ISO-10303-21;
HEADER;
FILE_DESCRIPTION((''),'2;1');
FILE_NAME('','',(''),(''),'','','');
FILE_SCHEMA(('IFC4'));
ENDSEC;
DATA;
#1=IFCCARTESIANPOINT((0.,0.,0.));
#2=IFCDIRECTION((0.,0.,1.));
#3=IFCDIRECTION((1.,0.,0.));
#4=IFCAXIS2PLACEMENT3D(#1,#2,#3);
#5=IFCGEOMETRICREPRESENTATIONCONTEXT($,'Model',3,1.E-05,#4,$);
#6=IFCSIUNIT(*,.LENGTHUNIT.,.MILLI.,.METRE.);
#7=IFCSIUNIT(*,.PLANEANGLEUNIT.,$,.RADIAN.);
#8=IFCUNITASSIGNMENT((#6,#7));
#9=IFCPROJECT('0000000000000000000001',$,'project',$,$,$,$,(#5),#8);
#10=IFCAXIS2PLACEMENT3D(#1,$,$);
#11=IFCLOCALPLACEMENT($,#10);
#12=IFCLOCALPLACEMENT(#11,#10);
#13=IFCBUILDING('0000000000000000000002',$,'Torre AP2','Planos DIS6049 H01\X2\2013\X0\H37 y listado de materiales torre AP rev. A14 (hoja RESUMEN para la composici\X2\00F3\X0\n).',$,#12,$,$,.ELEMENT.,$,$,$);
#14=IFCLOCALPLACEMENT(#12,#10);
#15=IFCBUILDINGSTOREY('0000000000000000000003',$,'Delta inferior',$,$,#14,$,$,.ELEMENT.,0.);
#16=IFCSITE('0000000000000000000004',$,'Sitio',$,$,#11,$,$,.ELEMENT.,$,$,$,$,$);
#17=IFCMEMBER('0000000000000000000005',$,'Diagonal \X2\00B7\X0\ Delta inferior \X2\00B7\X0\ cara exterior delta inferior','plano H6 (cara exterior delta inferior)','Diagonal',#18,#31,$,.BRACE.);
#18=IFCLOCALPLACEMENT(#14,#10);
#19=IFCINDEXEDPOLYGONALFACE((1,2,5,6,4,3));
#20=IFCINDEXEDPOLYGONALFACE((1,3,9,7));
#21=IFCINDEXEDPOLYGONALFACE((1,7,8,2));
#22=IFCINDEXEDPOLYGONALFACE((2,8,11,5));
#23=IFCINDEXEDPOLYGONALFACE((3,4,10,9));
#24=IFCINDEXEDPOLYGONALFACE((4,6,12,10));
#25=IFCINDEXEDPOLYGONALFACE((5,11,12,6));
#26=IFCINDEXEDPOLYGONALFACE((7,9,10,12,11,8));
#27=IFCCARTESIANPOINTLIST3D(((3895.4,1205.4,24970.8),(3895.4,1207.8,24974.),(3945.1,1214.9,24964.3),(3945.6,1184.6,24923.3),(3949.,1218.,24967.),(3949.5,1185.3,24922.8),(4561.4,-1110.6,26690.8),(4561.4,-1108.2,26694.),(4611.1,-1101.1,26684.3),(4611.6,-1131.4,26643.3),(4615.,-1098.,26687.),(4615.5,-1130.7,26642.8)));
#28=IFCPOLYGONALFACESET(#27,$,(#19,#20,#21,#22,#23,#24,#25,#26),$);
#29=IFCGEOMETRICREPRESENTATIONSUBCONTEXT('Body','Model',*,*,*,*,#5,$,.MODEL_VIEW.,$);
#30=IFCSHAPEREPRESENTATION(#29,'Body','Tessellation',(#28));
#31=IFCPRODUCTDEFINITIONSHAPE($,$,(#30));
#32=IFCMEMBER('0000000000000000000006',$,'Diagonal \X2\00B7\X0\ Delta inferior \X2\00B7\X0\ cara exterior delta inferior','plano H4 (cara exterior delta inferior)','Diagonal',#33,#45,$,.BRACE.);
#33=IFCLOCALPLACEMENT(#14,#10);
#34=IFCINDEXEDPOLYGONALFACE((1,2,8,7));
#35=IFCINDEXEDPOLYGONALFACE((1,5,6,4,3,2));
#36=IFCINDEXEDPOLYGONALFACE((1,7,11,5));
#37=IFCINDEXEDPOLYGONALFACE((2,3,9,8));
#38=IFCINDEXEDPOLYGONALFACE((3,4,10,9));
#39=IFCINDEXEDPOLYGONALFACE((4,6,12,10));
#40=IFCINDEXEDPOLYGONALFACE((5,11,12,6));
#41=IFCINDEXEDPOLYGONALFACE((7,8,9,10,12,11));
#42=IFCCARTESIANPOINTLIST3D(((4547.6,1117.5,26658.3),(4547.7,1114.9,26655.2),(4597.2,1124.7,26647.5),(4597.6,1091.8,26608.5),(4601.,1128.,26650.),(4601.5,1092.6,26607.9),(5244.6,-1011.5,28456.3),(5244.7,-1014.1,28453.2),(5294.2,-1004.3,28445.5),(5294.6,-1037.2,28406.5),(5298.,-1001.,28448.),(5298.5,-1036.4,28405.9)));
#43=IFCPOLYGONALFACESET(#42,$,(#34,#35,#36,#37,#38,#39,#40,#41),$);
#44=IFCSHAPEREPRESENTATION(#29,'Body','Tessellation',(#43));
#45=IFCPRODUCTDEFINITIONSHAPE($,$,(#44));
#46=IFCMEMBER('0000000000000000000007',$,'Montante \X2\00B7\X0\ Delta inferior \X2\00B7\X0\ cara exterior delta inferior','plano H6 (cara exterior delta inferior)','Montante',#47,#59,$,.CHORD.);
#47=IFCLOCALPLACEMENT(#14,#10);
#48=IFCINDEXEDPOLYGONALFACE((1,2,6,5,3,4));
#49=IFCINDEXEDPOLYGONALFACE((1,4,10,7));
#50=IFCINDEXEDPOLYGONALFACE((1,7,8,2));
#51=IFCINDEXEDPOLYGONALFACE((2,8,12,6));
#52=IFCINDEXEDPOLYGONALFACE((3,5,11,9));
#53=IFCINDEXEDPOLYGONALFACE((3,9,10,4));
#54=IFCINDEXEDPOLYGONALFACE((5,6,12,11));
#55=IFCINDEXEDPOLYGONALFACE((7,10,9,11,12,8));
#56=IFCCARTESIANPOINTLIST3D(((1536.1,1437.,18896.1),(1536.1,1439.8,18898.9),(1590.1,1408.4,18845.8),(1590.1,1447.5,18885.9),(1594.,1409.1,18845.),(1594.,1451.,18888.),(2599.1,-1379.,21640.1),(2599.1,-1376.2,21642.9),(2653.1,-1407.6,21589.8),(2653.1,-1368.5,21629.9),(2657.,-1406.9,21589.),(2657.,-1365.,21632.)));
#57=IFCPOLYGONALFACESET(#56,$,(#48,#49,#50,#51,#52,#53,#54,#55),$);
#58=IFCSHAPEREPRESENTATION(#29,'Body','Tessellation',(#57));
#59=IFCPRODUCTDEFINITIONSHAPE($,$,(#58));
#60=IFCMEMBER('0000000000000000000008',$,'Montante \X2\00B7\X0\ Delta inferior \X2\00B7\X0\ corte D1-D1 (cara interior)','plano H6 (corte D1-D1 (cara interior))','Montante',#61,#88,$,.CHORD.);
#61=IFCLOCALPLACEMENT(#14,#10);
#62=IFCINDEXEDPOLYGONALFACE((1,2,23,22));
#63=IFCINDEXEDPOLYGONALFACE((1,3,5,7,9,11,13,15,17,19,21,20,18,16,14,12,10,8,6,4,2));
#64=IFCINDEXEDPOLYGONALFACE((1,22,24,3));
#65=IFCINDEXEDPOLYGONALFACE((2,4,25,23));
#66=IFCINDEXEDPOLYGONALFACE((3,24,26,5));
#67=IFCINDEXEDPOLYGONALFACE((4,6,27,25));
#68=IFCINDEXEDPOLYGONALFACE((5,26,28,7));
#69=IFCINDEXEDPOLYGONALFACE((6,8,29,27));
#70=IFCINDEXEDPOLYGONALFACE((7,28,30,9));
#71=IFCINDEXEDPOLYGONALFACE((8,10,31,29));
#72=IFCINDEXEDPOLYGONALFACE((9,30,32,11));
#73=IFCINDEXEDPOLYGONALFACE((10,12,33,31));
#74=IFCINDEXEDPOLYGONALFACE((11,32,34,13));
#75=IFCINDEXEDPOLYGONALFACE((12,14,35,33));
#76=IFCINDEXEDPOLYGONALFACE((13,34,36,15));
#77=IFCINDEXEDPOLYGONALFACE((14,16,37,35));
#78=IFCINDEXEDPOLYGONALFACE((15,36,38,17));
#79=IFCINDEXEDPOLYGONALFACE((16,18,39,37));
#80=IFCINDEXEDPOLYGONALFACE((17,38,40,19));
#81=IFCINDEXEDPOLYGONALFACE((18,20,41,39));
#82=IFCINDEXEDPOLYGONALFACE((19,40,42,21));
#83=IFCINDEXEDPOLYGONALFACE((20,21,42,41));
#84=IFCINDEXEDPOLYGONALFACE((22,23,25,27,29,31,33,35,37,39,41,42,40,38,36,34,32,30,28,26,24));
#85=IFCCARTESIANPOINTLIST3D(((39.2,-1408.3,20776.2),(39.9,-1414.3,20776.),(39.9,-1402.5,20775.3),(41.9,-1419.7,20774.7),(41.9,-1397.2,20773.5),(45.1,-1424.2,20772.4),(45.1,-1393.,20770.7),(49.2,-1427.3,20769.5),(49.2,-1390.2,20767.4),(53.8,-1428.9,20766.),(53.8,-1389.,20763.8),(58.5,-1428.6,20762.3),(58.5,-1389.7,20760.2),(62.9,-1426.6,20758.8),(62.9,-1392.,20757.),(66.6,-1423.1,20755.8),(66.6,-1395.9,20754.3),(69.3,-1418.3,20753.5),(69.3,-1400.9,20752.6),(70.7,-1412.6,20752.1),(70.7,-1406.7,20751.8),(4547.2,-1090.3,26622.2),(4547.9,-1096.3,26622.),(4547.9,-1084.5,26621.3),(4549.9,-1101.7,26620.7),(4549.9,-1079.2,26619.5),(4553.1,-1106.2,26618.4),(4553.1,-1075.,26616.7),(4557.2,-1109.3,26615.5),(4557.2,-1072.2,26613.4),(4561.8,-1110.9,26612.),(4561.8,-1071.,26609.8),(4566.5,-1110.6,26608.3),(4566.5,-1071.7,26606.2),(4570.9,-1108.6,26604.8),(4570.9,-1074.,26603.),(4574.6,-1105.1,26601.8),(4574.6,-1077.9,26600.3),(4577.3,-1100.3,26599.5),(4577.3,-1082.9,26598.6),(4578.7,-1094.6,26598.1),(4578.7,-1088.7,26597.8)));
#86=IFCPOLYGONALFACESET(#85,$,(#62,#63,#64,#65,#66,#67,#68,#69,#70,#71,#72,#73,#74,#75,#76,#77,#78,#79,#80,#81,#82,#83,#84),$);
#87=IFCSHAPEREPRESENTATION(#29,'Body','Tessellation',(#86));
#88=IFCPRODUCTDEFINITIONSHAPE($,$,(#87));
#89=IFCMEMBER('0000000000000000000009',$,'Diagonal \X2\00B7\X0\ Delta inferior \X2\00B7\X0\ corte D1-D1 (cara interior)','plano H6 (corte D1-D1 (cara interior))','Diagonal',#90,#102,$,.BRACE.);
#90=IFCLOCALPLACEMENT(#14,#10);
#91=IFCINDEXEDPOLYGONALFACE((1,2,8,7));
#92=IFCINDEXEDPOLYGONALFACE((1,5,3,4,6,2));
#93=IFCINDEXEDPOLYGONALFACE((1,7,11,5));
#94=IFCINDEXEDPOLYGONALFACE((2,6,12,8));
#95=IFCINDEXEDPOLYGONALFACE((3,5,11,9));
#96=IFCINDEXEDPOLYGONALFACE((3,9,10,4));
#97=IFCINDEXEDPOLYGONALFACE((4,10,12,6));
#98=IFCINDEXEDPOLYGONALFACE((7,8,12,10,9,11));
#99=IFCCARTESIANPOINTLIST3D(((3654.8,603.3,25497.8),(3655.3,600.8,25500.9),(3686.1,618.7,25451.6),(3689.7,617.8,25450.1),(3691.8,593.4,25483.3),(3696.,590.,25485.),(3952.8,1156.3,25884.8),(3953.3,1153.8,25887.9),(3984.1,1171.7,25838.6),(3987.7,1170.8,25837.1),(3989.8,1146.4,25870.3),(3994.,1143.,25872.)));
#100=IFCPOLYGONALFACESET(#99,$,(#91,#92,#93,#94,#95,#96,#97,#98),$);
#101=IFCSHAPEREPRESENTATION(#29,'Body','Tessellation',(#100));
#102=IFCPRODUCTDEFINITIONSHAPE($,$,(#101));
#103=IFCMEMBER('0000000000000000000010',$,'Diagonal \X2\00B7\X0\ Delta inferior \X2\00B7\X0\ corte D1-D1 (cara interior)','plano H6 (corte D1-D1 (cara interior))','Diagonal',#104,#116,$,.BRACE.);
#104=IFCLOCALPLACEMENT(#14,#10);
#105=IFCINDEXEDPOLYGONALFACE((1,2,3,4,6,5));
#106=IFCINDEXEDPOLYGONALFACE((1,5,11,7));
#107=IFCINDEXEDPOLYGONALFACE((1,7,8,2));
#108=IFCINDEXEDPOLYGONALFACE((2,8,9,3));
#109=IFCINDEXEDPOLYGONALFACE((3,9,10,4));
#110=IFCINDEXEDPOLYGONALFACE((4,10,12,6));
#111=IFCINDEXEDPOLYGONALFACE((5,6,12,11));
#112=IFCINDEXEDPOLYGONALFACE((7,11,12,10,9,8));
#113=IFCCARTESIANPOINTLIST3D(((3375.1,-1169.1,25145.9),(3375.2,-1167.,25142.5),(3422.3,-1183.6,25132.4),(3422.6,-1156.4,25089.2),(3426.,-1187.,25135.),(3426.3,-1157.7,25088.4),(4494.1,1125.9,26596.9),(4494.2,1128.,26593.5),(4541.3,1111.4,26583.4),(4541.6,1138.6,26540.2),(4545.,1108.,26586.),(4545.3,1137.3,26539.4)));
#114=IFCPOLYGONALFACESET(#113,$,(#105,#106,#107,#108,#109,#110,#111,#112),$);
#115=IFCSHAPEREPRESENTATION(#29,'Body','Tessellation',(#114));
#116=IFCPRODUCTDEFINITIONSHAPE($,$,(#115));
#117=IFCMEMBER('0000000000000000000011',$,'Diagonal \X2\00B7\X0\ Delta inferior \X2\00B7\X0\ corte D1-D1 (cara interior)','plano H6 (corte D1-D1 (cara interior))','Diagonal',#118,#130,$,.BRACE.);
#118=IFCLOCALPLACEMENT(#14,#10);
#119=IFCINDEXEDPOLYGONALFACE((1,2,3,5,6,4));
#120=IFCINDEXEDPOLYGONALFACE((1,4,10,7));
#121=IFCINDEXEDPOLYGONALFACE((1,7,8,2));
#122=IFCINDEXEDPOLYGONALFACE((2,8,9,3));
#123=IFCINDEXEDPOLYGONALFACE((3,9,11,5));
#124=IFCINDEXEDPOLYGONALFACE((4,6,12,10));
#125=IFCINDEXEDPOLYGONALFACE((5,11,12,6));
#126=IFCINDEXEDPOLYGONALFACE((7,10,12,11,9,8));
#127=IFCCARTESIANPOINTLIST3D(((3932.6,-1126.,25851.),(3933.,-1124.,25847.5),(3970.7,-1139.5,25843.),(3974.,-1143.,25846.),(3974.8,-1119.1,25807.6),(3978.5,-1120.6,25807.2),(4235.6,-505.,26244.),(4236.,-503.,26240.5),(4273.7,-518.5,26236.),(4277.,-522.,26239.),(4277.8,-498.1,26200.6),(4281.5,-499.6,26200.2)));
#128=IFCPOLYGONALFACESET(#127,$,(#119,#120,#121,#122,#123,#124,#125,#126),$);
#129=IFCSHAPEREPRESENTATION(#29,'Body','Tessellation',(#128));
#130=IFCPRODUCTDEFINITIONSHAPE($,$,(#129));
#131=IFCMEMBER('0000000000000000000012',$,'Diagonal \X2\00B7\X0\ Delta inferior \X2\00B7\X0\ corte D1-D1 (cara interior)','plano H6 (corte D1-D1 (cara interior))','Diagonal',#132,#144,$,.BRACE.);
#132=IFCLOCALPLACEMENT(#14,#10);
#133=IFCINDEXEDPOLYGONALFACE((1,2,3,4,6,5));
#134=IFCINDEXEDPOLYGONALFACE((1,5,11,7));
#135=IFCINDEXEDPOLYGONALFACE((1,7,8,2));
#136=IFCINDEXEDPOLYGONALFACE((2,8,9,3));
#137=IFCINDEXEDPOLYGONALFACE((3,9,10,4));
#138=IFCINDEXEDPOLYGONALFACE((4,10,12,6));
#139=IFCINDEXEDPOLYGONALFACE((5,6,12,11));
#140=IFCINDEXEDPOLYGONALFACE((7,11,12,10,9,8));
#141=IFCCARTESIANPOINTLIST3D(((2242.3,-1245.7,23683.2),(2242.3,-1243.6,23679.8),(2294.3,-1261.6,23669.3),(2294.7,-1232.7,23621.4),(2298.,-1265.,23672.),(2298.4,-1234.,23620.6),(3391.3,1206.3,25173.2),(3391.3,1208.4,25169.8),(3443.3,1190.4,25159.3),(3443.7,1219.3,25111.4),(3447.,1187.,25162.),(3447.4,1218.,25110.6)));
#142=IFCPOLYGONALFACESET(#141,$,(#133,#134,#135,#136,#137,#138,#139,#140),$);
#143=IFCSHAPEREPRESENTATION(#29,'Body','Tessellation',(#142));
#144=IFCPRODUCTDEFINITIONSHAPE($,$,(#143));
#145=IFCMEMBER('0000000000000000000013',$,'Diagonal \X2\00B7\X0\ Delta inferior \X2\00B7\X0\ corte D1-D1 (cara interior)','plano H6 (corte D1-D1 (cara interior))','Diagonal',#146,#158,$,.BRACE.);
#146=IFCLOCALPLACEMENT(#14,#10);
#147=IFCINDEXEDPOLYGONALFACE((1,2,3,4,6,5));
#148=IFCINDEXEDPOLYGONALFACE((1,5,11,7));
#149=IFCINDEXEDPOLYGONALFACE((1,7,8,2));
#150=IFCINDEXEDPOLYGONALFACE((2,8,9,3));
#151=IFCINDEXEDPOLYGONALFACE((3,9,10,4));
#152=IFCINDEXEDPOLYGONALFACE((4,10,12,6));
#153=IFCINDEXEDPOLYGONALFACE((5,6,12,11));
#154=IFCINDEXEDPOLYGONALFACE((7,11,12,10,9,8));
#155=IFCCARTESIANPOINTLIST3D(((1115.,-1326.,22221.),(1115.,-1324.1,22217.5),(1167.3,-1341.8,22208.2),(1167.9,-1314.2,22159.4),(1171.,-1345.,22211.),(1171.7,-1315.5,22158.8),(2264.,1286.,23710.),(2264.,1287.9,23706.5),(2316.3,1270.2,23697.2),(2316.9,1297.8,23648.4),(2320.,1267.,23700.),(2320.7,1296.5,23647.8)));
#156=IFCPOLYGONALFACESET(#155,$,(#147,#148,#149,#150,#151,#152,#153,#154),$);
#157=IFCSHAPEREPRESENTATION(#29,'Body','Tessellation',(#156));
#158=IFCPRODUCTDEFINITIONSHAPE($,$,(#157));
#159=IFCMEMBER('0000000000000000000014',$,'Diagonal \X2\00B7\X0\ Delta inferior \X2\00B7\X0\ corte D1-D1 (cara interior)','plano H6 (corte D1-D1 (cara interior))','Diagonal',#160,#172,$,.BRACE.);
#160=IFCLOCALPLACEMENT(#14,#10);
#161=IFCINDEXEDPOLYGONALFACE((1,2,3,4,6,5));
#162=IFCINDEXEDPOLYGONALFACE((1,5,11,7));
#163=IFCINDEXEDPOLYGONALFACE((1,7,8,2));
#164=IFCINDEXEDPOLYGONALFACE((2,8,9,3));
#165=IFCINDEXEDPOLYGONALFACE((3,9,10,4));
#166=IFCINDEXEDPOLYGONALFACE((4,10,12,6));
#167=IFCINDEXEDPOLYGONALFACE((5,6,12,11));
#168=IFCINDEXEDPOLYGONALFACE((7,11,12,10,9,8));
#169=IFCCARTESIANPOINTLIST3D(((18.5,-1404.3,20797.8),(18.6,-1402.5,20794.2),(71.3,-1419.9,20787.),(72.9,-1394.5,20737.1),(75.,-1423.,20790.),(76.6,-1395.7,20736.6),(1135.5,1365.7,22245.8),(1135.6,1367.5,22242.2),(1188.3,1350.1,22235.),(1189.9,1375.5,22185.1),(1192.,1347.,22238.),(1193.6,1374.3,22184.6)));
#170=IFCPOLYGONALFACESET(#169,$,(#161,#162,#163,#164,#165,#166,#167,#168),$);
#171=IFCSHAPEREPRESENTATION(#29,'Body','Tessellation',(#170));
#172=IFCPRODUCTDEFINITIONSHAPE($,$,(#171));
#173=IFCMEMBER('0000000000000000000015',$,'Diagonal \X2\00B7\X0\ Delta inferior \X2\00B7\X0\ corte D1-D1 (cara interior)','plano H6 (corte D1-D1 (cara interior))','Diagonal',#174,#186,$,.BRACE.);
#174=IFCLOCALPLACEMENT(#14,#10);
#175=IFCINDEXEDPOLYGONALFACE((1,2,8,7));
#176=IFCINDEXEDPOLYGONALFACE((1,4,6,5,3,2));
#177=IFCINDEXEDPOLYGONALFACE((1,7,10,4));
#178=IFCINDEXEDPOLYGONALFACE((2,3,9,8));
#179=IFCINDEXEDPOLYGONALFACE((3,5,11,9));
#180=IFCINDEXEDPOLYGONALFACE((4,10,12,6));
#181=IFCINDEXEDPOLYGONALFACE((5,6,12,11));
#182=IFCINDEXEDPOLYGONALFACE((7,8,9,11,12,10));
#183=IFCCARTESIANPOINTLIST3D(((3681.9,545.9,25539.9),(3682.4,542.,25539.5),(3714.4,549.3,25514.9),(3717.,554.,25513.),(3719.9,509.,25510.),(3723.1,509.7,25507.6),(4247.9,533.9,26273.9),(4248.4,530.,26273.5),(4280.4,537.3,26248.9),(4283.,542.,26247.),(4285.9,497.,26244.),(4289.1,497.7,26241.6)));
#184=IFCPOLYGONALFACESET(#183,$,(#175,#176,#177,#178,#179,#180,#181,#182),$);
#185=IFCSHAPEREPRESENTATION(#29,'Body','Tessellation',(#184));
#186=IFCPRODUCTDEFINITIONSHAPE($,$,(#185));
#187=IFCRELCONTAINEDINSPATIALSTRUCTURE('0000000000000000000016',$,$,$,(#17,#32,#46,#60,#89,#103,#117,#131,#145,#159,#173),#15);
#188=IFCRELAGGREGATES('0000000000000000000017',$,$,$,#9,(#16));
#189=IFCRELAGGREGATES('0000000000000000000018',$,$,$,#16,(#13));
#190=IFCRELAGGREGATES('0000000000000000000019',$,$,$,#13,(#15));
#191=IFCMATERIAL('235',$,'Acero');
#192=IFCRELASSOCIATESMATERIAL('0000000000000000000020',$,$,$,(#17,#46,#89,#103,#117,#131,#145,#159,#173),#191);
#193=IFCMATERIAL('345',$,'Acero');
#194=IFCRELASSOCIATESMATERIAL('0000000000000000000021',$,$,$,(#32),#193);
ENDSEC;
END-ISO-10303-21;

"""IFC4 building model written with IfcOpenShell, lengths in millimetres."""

from ifc_helpers import new_model, si_unit, frame, frame_2d, origin, origin_with_axes, place, context, subcontext, project, spatial, circle, l_section, extrude, material, element, save


model = new_model("IFC4")

# Units and contexts
model_context = context("Model", 3, precision=1e-05, world=origin_with_axes())
body_context = subcontext(model_context, "Body", "Model", "MODEL_VIEW")
ifc_project = project(units=[si_unit("LENGTHUNIT", "METRE", prefix="MILLI"), si_unit("PLANEANGLEUNIT", "RADIAN")], contexts=[model_context])

# Site, building, storey
site_placement = place(None, origin())
site = spatial("IfcSite", under=ifc_project, at=site_placement, Name="Sitio", CompositionType="ELEMENT")
building_placement = place(site_placement, origin())
building = spatial("IfcBuilding", under=site, at=building_placement, Name="Torre AP2", Description="Planos DIS6049 H01–H37 y listado de materiales torre AP rev. A14 (hoja RESUMEN para la composición).", CompositionType="ELEMENT")
storey_placement = place(building_placement, origin())
storey = spatial("IfcBuildingStorey", under=building, at=storey_placement, Name="Delta inferior", CompositionType="ELEMENT", Elevation=0.0)

# Members
ifc_material_1 = material(Name="235", Category="Acero")
ifc_material_2 = material(Name="345", Category="Acero")
member_1_placement = place(storey_placement, frame((3949.0, 1218.0, 24967.0), z_axis=(0.224946, -0.782244, 0.580941), x_axis=(-0.974336, -0.185683, 0.127247)))
element("IfcMember", 1, at=member_1_placement, inside=storey, material=ifc_material_1, Name="Diagonal · Delta inferior · cara exterior delta inferior", Description="plano H6 (cara exterior delta inferior)", ObjectType="Diagonal", PredefinedType="BRACE", context=body_context, shape_type="SweptSolid", body=[
    extrude(l_section(Depth=55.0, Width=55.0, Thickness=4.0, at=frame_2d((27.5, 27.5))), None, (0.0, 0.0, 1.0), 2960.7),
])
member_2_placement = place(storey_placement, frame((4601.0, 1128.0, 26650.0), z_axis=(0.242646, -0.741166, 0.625936), x_axis=(-0.97008, -0.190866, 0.150051)))
element("IfcMember", 2, at=member_2_placement, inside=storey, material=ifc_material_2, Name="Diagonal · Delta inferior · cara exterior delta inferior", Description="plano H4 (cara exterior delta inferior)", ObjectType="Diagonal", PredefinedType="BRACE", context=body_context, shape_type="SweptSolid", body=[
    extrude(l_section(Depth=55.0, Width=55.0, Thickness=4.0, at=frame_2d((27.5, 27.5))), None, (0.0, 0.0, 1.0), 2872.5),
])
member_3_placement = place(storey_placement, frame((1594.0, 1451.0, 18888.0), z_axis=(0.260987, -0.691382, 0.673704), x_axis=(-0.965342, -0.18692, 0.18214)))
element("IfcMember", 3, at=member_3_placement, inside=storey, material=ifc_material_1, Name="Montante · Delta inferior · cara exterior delta inferior", Description="plano H6 (cara exterior delta inferior)", ObjectType="Montante", PredefinedType="CHORD", context=body_context, shape_type="SweptSolid", body=[
    extrude(l_section(Depth=60.0, Width=60.0, Thickness=4.0, at=frame_2d((30.0, 30.0))), None, (0.0, 0.0, 1.0), 4073.0),
])
member_4_placement = place(storey_placement, frame((4563.0, -1091.0, 26610.0), z_axis=(-0.610087, -0.043036, -0.791165), x_axis=(-0.792334, 0.033137, 0.609187)))
element("IfcMember", 4, at=member_4_placement, inside=storey, Name="Montante · Delta inferior · corte D1-D1 (cara interior)", Description="plano H6 (corte D1-D1 (cara interior))", ObjectType="Montante", PredefinedType="CHORD", context=body_context, shape_type="SweptSolid", body=[
    extrude(circle(Radius=20.0), None, (0.0, 0.0, 1.0), 7389.1),
])
member_5_placement = place(storey_placement, frame((3994.0, 1143.0, 25872.0), z_axis=(-0.403891, -0.749503, -0.524516), x_axis=(-0.904178, 0.239916, 0.353414)))
element("IfcMember", 5, at=member_5_placement, inside=storey, material=ifc_material_1, Name="Diagonal · Delta inferior · corte D1-D1 (cara interior)", Description="plano H6 (corte D1-D1 (cara interior))", ObjectType="Diagonal", PredefinedType="BRACE", context=body_context, shape_type="SweptSolid", body=[
    extrude(l_section(Depth=45.0, Width=45.0, Thickness=4.0, at=frame_2d((22.5, 22.5))), None, (0.0, 0.0, 1.0), 737.8),
])
member_6_placement = place(storey_placement, frame((4545.0, 1108.0, 26586.0), z_axis=(-0.381032, -0.781472, -0.494081), x_axis=(-0.924547, 0.325107, 0.198793)))
element("IfcMember", 6, at=member_6_placement, inside=storey, material=ifc_material_1, Name="Diagonal · Delta inferior · corte D1-D1 (cara interior)", Description="plano H6 (corte D1-D1 (cara interior))", ObjectType="Diagonal", PredefinedType="BRACE", context=body_context, shape_type="SweptSolid", body=[
    extrude(l_section(Depth=55.0, Width=55.0, Thickness=4.0, at=frame_2d((27.5, 27.5))), None, (0.0, 0.0, 1.0), 2936.8),
])
member_7_placement = place(storey_placement, frame((4277.0, -522.0, 26239.0), z_axis=(-0.38117, -0.78121, -0.494389), x_axis=(-0.919056, 0.378167, 0.111023)))
element("IfcMember", 7, at=member_7_placement, inside=storey, material=ifc_material_1, Name="Diagonal · Delta inferior · corte D1-D1 (cara interior)", Description="plano H6 (corte D1-D1 (cara interior))", ObjectType="Diagonal", PredefinedType="BRACE", context=body_context, shape_type="SweptSolid", body=[
    extrude(l_section(Depth=45.0, Width=45.0, Thickness=4.0, at=frame_2d((22.5, 22.5))), None, (0.0, 0.0, 1.0), 794.9),
])
member_8_placement = place(storey_placement, frame((3447.0, 1187.0, 25162.0), z_axis=(-0.371757, -0.79334, -0.482087), x_axis=(-0.928304, 0.321616, 0.18659)))
element("IfcMember", 8, at=member_8_placement, inside=storey, material=ifc_material_1, Name="Diagonal · Delta inferior · corte D1-D1 (cara interior)", Description="plano H6 (corte D1-D1 (cara interior))", ObjectType="Diagonal", PredefinedType="BRACE", context=body_context, shape_type="SweptSolid", body=[
    extrude(l_section(Depth=60.0, Width=60.0, Thickness=4.0, at=frame_2d((30.0, 30.0))), None, (0.0, 0.0, 1.0), 3090.7),
])
member_9_placement = place(storey_placement, frame((2320.0, 1267.0, 23700.0), z_axis=(-0.356979, -0.811514, -0.462613), x_axis=(-0.934048, 0.315929, 0.166565)))
element("IfcMember", 9, at=member_9_placement, inside=storey, material=ifc_material_1, Name="Diagonal · Delta inferior · corte D1-D1 (cara interior)", Description="plano H6 (corte D1-D1 (cara interior))", ObjectType="Diagonal", PredefinedType="BRACE", context=body_context, shape_type="SweptSolid", body=[
    extrude(l_section(Depth=60.0, Width=60.0, Thickness=4.0, at=frame_2d((30.0, 30.0))), None, (0.0, 0.0, 1.0), 3218.7),
])
member_10_placement = place(storey_placement, frame((1192.0, 1347.0, 22238.0), z_axis=(-0.336524, -0.834531, -0.436246), x_axis=(-0.94128, 0.311519, 0.130181)))
element("IfcMember", 10, at=member_10_placement, inside=storey, material=ifc_material_1, Name="Diagonal · Delta inferior · corte D1-D1 (cara interior)", Description="plano H6 (corte D1-D1 (cara interior))", ObjectType="Diagonal", PredefinedType="BRACE", context=body_context, shape_type="SweptSolid", body=[
    extrude(l_section(Depth=60.0, Width=60.0, Thickness=4.0, at=frame_2d((30.0, 30.0))), None, (0.0, 0.0, 1.0), 3319.2),
])
member_11_placement = place(storey_placement, frame((3717.0, 554.0, 25513.0), z_axis=(0.610598, -0.012946, 0.791835), x_axis=(-0.780393, -0.179966, 0.598832)))
element("IfcMember", 11, at=member_11_placement, inside=storey, material=ifc_material_1, Name="Diagonal · Delta inferior · corte D1-D1 (cara interior)", Description="plano H6 (corte D1-D1 (cara interior))", ObjectType="Diagonal", PredefinedType="BRACE", context=body_context, shape_type="SweptSolid", body=[
    extrude(l_section(Depth=45.0, Width=45.0, Thickness=4.0, at=frame_2d((22.5, 22.5))), None, (0.0, 0.0, 1.0), 927.0),
])

save(model, "model.ifc")
